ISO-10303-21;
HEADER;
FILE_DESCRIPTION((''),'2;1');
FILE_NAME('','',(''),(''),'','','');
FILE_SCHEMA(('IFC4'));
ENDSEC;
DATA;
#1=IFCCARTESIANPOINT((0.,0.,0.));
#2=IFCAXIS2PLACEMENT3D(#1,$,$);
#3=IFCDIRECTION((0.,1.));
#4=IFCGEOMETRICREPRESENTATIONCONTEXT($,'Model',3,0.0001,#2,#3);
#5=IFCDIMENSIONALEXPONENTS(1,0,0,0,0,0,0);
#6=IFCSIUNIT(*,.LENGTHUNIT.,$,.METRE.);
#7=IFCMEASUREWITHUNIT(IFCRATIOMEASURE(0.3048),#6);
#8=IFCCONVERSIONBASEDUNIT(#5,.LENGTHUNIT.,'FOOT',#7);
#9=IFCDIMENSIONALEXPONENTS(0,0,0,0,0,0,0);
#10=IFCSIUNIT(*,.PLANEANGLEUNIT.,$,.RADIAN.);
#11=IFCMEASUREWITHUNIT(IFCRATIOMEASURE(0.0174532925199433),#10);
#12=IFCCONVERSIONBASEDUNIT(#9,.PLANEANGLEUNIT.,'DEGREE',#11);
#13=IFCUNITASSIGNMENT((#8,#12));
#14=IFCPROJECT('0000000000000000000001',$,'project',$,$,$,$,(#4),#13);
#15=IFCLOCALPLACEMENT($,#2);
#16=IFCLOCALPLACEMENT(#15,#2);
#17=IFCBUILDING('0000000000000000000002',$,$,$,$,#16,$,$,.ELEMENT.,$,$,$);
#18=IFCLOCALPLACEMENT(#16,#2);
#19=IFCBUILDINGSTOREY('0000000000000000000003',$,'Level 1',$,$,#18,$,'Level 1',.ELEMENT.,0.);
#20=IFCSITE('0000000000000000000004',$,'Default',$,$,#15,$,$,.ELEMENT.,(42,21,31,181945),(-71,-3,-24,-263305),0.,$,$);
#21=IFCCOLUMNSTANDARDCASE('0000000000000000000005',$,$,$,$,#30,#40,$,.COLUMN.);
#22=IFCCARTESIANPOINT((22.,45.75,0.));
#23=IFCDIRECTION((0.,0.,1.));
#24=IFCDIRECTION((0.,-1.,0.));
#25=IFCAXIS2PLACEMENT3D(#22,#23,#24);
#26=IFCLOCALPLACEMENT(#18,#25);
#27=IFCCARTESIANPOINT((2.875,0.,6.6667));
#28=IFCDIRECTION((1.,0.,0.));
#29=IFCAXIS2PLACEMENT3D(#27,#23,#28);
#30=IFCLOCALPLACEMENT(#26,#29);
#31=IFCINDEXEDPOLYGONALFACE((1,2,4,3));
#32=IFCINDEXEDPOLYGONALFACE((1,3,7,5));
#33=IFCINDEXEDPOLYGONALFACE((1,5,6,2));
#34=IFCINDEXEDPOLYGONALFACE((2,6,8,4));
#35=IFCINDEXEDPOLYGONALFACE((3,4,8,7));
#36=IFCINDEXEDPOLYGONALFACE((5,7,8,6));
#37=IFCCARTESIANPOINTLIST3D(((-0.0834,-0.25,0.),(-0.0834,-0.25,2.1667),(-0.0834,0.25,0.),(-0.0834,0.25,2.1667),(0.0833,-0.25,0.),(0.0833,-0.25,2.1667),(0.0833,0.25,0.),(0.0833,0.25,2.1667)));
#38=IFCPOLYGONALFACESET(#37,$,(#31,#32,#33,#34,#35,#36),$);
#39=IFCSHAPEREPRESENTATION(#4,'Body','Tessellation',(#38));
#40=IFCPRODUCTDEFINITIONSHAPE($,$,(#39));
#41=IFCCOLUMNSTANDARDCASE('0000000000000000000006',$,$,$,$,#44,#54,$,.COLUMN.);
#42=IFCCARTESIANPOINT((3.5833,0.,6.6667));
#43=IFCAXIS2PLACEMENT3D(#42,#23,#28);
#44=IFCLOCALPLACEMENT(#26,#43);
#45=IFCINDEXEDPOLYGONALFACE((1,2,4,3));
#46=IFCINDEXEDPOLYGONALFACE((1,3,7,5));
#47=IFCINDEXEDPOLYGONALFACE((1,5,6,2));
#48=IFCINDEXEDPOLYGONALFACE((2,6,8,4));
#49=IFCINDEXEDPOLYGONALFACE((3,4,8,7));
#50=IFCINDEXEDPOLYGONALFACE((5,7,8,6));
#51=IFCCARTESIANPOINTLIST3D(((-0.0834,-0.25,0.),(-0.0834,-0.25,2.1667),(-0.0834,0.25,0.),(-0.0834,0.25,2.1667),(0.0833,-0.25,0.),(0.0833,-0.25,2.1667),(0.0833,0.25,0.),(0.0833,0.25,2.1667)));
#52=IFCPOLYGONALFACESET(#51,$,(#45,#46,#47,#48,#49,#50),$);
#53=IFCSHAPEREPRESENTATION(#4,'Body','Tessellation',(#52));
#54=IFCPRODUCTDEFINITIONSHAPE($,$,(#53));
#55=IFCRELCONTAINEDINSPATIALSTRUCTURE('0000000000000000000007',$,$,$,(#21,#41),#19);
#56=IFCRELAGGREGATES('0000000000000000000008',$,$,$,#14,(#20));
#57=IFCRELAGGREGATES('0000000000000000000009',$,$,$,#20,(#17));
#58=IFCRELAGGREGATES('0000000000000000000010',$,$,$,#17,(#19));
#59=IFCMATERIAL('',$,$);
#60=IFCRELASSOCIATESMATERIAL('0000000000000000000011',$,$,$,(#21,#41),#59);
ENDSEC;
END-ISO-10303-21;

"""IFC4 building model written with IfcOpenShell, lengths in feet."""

from ifc_helpers import new_model, entity, si_unit, converted_unit, direction, frame, origin, place, context, project, spatial, rectangle, extrude, material, element, save


model = new_model("IFC4")

# Units and contexts
model_context = context("Model", 3, precision=0.0001, world=origin(), true_north=direction((0.0, 1.0)))
ifc_project = project(units=[converted_unit("LENGTHUNIT", "FOOT", entity("IfcRatioMeasure", 0.3048), si_unit("LENGTHUNIT", "METRE"), dimensions=[1, 0, 0, 0, 0, 0, 0]), converted_unit("PLANEANGLEUNIT", "DEGREE", entity("IfcRatioMeasure", 0.0174532925199433), si_unit("PLANEANGLEUNIT", "RADIAN"), dimensions=[0, 0, 0, 0, 0, 0, 0])], contexts=[model_context])

# Site, building, storey
site_placement = place(None, origin())
site = spatial("IfcSite", under=ifc_project, at=site_placement, Name="Default", CompositionType="ELEMENT", RefLatitude=(42, 21, 31, 181945), RefLongitude=(-71, -3, -24, -263305), RefElevation=0.0)
building_placement = place(site_placement, origin())
building = spatial("IfcBuilding", under=site, at=building_placement, CompositionType="ELEMENT")
storey_placement = place(building_placement, origin())
storey = spatial("IfcBuildingStorey", under=building, at=storey_placement, Name="Level 1", LongName="Level 1", CompositionType="ELEMENT", Elevation=0.0)

# Columns
ifc_material_1 = material(Name="")
placement_1 = place(storey_placement, frame((22.0, 45.75, 0.0), z_axis=(0.0, 0.0, 1.0), x_axis=(0.0, -1.0, 0.0)))
for number, where, z_axis, x_axis in (
    (1, (2.875, 0.0, 6.6667), (0.0, 0.0, 1.0), (1.0, 0.0, 0.0)),
    (2, (3.5833, 0.0, 6.6667), (0.0, 0.0, 1.0), (1.0, 0.0, 0.0)),
):
    element("IfcColumnStandardCase", number, at=place(placement_1, frame(where, z_axis=z_axis, x_axis=x_axis)), inside=storey, material=ifc_material_1, PredefinedType="COLUMN", context=model_context, shape_type="SweptSolid", body=[
        extrude(rectangle(XDim=0.1667, YDim=0.5), origin(), (0.0, 0.0, 1.0), 2.1667),
    ])

save(model, "model.ifc")
